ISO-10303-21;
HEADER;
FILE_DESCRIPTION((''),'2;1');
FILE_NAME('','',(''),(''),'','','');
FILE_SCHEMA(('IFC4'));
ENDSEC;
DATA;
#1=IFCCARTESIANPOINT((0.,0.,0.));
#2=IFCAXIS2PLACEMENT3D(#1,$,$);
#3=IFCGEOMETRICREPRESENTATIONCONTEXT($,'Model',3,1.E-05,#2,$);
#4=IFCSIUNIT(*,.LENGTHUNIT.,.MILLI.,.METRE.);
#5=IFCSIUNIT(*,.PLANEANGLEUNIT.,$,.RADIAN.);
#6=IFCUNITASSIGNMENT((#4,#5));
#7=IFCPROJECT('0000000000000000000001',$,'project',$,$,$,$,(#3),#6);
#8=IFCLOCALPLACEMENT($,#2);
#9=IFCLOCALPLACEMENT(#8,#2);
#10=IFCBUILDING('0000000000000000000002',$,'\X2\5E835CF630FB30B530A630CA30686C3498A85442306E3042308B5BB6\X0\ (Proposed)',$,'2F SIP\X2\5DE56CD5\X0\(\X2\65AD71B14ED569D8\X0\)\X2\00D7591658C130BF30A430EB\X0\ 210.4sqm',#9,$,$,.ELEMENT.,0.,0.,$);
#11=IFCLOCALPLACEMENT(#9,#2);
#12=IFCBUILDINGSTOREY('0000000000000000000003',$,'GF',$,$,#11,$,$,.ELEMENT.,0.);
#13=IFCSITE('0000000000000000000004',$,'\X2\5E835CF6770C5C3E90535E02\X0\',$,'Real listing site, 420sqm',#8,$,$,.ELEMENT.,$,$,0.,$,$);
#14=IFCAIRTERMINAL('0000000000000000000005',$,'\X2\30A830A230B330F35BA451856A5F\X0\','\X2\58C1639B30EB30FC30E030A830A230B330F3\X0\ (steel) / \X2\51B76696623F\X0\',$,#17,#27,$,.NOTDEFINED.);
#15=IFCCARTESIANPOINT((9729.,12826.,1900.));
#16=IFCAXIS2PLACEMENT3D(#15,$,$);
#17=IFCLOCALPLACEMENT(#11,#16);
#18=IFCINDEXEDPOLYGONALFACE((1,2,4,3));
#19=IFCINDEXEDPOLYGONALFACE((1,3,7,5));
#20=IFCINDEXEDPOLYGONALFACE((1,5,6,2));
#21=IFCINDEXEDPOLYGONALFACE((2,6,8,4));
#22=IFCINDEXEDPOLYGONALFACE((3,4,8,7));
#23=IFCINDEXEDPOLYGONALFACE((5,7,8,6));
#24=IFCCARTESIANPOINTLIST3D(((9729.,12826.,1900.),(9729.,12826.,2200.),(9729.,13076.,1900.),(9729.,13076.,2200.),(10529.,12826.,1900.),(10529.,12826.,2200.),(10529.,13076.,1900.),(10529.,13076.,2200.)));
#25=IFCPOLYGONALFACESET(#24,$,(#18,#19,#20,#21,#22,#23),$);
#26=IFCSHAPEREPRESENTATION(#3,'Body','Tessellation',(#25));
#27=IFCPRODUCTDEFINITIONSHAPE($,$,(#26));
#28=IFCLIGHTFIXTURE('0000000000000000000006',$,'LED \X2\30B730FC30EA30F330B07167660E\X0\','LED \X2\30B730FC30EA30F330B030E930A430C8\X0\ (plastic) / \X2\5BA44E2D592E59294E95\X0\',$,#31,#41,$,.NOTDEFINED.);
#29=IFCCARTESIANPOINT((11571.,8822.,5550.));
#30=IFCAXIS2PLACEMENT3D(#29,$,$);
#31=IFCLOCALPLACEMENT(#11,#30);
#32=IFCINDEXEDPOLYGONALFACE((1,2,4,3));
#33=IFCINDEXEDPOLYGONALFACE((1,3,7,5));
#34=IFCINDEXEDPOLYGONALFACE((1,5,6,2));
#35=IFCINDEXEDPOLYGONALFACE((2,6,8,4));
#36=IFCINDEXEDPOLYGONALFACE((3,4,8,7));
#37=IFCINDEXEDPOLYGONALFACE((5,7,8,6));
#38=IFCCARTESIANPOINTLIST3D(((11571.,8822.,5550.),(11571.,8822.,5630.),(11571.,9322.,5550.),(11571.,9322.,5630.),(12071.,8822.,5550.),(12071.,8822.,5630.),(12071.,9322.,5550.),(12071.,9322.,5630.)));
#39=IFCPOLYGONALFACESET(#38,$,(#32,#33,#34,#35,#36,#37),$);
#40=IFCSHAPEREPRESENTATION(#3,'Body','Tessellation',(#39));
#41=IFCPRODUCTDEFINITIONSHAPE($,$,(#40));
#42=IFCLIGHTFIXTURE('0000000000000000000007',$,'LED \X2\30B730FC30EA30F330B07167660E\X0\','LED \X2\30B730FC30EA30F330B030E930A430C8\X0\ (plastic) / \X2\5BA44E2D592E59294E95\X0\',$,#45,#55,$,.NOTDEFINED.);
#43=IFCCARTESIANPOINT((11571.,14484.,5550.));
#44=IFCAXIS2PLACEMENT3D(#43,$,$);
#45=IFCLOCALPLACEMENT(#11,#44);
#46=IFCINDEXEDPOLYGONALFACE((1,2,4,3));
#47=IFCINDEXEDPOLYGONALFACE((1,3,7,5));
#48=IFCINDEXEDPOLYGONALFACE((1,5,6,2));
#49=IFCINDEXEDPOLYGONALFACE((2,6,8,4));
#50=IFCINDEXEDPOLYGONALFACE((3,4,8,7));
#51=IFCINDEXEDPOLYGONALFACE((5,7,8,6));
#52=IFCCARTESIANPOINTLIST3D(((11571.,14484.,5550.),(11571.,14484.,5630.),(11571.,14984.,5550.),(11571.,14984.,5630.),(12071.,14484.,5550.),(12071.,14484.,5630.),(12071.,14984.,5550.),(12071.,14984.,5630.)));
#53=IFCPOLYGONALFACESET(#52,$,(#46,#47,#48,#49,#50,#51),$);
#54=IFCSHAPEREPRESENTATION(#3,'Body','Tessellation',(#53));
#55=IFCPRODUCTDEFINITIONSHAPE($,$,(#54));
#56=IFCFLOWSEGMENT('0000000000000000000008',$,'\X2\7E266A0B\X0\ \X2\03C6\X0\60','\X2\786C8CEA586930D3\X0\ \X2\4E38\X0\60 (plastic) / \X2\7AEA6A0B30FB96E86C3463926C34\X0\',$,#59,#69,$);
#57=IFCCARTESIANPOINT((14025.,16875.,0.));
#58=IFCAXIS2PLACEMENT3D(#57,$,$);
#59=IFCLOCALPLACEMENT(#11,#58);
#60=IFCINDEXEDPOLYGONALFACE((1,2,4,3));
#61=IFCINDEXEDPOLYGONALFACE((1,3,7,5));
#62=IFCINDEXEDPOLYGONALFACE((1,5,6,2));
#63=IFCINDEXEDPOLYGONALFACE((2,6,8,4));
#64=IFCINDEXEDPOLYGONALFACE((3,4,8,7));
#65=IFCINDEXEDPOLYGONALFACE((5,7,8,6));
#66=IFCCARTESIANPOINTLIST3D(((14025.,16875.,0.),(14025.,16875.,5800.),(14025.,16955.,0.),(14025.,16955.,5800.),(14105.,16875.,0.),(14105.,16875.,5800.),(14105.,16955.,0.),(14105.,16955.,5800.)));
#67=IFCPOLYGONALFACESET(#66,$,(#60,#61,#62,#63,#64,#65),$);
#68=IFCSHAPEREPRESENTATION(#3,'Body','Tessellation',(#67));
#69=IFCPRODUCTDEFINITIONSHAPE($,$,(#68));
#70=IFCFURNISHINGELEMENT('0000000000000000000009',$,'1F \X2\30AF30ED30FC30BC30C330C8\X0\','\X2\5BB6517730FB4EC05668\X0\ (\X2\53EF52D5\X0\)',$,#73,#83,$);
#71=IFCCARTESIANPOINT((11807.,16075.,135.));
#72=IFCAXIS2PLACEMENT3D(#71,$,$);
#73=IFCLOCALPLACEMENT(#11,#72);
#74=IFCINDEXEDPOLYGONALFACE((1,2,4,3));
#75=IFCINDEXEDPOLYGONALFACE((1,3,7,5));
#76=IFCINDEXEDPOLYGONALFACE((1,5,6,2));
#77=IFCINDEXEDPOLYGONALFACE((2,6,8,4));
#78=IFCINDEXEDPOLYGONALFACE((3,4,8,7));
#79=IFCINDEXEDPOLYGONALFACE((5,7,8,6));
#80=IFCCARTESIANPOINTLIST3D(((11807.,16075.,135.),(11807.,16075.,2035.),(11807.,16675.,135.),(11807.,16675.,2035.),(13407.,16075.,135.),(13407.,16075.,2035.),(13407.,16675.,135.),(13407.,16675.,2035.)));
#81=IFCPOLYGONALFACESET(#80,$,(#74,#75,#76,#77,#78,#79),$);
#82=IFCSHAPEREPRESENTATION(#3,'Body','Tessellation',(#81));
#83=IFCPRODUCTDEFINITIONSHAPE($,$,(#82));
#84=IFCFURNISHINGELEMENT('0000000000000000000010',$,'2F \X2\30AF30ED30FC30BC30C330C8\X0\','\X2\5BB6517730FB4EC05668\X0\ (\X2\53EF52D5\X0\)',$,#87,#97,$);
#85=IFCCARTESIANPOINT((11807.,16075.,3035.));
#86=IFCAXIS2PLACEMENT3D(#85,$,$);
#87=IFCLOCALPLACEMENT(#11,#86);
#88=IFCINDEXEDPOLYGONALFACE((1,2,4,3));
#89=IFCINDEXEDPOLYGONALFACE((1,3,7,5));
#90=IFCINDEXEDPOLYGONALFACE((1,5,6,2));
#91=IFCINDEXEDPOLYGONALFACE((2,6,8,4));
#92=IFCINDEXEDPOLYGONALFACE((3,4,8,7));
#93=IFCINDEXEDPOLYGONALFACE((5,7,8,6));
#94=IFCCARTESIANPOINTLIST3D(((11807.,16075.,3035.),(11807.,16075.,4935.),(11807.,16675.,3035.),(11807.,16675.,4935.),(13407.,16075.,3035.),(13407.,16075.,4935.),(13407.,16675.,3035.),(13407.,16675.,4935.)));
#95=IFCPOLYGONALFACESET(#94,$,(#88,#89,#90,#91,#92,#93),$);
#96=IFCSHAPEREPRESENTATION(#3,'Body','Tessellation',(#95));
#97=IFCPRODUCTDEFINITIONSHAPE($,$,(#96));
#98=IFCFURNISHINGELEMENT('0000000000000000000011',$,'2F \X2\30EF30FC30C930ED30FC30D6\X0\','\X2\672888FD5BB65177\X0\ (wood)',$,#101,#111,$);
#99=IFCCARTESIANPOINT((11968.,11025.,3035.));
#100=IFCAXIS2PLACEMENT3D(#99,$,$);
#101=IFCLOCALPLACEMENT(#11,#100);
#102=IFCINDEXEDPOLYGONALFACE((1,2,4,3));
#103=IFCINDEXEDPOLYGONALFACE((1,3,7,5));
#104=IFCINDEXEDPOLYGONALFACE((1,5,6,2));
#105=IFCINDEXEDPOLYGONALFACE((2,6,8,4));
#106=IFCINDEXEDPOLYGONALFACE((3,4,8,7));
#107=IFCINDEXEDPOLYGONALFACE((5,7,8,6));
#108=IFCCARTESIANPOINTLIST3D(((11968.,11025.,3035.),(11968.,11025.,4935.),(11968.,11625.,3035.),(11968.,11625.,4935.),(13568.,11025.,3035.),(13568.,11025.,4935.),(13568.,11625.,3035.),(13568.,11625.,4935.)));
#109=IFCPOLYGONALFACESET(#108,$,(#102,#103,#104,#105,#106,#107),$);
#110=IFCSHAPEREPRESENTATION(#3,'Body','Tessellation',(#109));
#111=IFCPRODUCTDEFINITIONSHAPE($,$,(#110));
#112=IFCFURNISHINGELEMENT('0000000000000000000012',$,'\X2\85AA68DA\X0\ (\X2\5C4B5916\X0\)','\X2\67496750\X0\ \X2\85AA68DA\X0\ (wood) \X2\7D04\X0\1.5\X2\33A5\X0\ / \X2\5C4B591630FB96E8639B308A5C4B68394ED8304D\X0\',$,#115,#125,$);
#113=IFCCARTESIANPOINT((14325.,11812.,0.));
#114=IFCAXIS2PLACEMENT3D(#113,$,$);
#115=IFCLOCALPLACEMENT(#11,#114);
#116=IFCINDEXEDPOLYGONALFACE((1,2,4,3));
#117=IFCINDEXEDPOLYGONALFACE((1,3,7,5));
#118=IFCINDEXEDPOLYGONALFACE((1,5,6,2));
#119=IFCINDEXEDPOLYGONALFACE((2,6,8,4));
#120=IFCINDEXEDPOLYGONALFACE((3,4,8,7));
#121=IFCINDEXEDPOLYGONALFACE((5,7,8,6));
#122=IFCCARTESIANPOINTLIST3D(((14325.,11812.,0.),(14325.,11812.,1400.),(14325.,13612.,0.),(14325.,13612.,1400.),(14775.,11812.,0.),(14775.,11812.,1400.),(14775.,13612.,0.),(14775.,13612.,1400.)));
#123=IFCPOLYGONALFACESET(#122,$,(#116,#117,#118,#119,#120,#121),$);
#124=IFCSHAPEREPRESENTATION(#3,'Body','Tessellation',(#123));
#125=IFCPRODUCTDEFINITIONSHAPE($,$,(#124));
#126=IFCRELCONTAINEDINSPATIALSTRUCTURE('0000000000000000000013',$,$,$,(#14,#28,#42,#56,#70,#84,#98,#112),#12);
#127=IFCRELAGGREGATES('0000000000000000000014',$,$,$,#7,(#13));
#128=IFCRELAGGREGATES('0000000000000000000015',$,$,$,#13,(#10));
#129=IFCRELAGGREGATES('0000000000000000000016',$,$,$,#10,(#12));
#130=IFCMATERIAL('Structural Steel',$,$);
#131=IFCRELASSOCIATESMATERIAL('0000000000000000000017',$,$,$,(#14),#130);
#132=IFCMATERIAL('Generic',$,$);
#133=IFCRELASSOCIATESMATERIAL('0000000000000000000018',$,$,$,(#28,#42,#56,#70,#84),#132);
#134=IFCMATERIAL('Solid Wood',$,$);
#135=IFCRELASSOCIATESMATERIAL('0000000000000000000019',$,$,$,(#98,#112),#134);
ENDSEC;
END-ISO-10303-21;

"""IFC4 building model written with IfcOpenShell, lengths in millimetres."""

from ifc_helpers import new_model, si_unit, frame, frame_2d, origin, place, context, project, spatial, rectangle, extrude, material, element, save


model = new_model("IFC4")

# Units and contexts
model_context = context("Model", 3, precision=1e-05, world=origin())
ifc_project = project(units=[si_unit("LENGTHUNIT", "METRE", prefix="MILLI"), si_unit("PLANEANGLEUNIT", "RADIAN")], contexts=[model_context])

# Site, building, storey
site_placement = place(None, origin())
site = spatial("IfcSite", under=ifc_project, at=site_placement, Name="広島県尾道市", ObjectType="Real listing site, 420sqm", CompositionType="ELEMENT", RefElevation=0.0)
building_placement = place(site_placement, origin())
building = spatial("IfcBuilding", under=site, at=building_placement, Name="広島・サウナと水風呂のある家 (Proposed)", ObjectType="2F SIP工法(断熱仕様)×外壁タイル 210.4sqm", CompositionType="ELEMENT", ElevationOfRefHeight=0.0, ElevationOfTerrain=0.0)
storey_placement = place(building_placement, origin())
storey = spatial("IfcBuildingStorey", under=building, at=storey_placement, Name="GF", CompositionType="ELEMENT", Elevation=0.0)

# Shared definitions
ifc_material_1 = material(Name="Solid Wood")

# Shared definitions
ifc_material_2 = material(Name="Structural Steel")

# Shared definitions
ifc_material_3 = material(Name="Generic")

# Air terminal
air_terminal_placement = place(storey_placement, frame((9729.0, 12826.0, 1900.0)))
element("IfcAirTerminal", 1, at=air_terminal_placement, inside=storey, material=ifc_material_2, Name="エアコン室内機", Description="壁掛ルームエアコン (steel) / 冷暖房", PredefinedType="NOTDEFINED", context=model_context, shape_type="SweptSolid", body=[
    extrude(rectangle(XDim=800.0, YDim=250.0, at=frame_2d((400.0, 125.0))), frame((9729.0, 12826.0, 1900.0)), (0.0, 0.0, 1.0), 300.0),
])

# Light fixtures
light_fixture_1_placement = place(storey_placement, frame((11571.0, 8822.0, 5550.0)))
element("IfcLightFixture", 2, at=light_fixture_1_placement, inside=storey, material=ifc_material_3, Name="LED シーリング照明", Description="LED シーリングライト (plastic) / 室中央天井", PredefinedType="NOTDEFINED", context=model_context, shape_type="SweptSolid", body=[
    extrude(rectangle(XDim=500.0, YDim=500.0, at=frame_2d((250.0, 250.0))), frame((11571.0, 8822.0, 5550.0)), (0.0, 0.0, 1.0), 80.0),
])
light_fixture_2_placement = place(storey_placement, frame((11571.0, 14484.0, 5550.0)))
element("IfcLightFixture", 3, at=light_fixture_2_placement, inside=storey, material=ifc_material_3, Name="LED シーリング照明", Description="LED シーリングライト (plastic) / 室中央天井", PredefinedType="NOTDEFINED", context=model_context, shape_type="SweptSolid", body=[
    extrude(rectangle(XDim=500.0, YDim=500.0, at=frame_2d((250.0, 250.0))), frame((11571.0, 14484.0, 5550.0)), (0.0, 0.0, 1.0), 80.0),
])

# Flow segment
flow_segment_placement = place(storey_placement, frame((14025.0, 16875.0, 0.0)))
element("IfcFlowSegment", 4, at=flow_segment_placement, inside=storey, material=ifc_material_3, Name="縦樋 φ60", Description="硬質塩ビ 丸60 (plastic) / 竪樋・雨水排水", context=model_context, shape_type="SweptSolid", body=[
    extrude(rectangle(XDim=80.0, YDim=80.0, at=frame_2d((40.0, 40.0))), frame((14025.0, 16875.0, 0.0)), (0.0, 0.0, 1.0), 5800.0),
])

# Furnishing elements
furnishing_1_placement = place(storey_placement, frame((11807.0, 16075.0, 135.0)))
element("IfcFurnishingElement", 5, at=furnishing_1_placement, inside=storey, material=ifc_material_3, Name="1F クローゼット", Description="家具・什器 (可動)", context=model_context, shape_type="SweptSolid", body=[
    extrude(rectangle(XDim=1600.0, YDim=600.0, at=frame_2d((800.0, 300.0))), frame((11807.0, 16075.0, 135.0)), (0.0, 0.0, 1.0), 1900.0),
])
furnishing_2_placement = place(storey_placement, frame((11807.0, 16075.0, 3035.0)))
element("IfcFurnishingElement", 6, at=furnishing_2_placement, inside=storey, material=ifc_material_3, Name="2F クローゼット", Description="家具・什器 (可動)", context=model_context, shape_type="SweptSolid", body=[
    extrude(rectangle(XDim=1600.0, YDim=600.0, at=frame_2d((800.0, 300.0))), frame((11807.0, 16075.0, 3035.0)), (0.0, 0.0, 1.0), 1900.0),
])
furnishing_3_placement = place(storey_placement, frame((11968.0, 11025.0, 3035.0)))
element("IfcFurnishingElement", 7, at=furnishing_3_placement, inside=storey, material=ifc_material_1, Name="2F ワードローブ", Description="木製家具 (wood)", context=model_context, shape_type="SweptSolid", body=[
    extrude(rectangle(XDim=1600.0, YDim=600.0, at=frame_2d((800.0, 300.0))), frame((11968.0, 11025.0, 3035.0)), (0.0, 0.0, 1.0), 1900.0),
])
furnishing_4_placement = place(storey_placement, frame((14325.0, 11812.0, 0.0)))
element("IfcFurnishingElement", 8, at=furnishing_4_placement, inside=storey, material=ifc_material_1, Name="薪棚 (屋外)", Description="杉材 薪棚 (wood) 約1.5㎥ / 屋外・雨掛り屋根付き", context=model_context, shape_type="SweptSolid", body=[
    extrude(rectangle(XDim=450.0, YDim=1800.0, at=frame_2d((225.0, 900.0))), frame((14325.0, 11812.0, 0.0)), (0.0, 0.0, 1.0), 1400.0),
])

save(model, "model.ifc")
